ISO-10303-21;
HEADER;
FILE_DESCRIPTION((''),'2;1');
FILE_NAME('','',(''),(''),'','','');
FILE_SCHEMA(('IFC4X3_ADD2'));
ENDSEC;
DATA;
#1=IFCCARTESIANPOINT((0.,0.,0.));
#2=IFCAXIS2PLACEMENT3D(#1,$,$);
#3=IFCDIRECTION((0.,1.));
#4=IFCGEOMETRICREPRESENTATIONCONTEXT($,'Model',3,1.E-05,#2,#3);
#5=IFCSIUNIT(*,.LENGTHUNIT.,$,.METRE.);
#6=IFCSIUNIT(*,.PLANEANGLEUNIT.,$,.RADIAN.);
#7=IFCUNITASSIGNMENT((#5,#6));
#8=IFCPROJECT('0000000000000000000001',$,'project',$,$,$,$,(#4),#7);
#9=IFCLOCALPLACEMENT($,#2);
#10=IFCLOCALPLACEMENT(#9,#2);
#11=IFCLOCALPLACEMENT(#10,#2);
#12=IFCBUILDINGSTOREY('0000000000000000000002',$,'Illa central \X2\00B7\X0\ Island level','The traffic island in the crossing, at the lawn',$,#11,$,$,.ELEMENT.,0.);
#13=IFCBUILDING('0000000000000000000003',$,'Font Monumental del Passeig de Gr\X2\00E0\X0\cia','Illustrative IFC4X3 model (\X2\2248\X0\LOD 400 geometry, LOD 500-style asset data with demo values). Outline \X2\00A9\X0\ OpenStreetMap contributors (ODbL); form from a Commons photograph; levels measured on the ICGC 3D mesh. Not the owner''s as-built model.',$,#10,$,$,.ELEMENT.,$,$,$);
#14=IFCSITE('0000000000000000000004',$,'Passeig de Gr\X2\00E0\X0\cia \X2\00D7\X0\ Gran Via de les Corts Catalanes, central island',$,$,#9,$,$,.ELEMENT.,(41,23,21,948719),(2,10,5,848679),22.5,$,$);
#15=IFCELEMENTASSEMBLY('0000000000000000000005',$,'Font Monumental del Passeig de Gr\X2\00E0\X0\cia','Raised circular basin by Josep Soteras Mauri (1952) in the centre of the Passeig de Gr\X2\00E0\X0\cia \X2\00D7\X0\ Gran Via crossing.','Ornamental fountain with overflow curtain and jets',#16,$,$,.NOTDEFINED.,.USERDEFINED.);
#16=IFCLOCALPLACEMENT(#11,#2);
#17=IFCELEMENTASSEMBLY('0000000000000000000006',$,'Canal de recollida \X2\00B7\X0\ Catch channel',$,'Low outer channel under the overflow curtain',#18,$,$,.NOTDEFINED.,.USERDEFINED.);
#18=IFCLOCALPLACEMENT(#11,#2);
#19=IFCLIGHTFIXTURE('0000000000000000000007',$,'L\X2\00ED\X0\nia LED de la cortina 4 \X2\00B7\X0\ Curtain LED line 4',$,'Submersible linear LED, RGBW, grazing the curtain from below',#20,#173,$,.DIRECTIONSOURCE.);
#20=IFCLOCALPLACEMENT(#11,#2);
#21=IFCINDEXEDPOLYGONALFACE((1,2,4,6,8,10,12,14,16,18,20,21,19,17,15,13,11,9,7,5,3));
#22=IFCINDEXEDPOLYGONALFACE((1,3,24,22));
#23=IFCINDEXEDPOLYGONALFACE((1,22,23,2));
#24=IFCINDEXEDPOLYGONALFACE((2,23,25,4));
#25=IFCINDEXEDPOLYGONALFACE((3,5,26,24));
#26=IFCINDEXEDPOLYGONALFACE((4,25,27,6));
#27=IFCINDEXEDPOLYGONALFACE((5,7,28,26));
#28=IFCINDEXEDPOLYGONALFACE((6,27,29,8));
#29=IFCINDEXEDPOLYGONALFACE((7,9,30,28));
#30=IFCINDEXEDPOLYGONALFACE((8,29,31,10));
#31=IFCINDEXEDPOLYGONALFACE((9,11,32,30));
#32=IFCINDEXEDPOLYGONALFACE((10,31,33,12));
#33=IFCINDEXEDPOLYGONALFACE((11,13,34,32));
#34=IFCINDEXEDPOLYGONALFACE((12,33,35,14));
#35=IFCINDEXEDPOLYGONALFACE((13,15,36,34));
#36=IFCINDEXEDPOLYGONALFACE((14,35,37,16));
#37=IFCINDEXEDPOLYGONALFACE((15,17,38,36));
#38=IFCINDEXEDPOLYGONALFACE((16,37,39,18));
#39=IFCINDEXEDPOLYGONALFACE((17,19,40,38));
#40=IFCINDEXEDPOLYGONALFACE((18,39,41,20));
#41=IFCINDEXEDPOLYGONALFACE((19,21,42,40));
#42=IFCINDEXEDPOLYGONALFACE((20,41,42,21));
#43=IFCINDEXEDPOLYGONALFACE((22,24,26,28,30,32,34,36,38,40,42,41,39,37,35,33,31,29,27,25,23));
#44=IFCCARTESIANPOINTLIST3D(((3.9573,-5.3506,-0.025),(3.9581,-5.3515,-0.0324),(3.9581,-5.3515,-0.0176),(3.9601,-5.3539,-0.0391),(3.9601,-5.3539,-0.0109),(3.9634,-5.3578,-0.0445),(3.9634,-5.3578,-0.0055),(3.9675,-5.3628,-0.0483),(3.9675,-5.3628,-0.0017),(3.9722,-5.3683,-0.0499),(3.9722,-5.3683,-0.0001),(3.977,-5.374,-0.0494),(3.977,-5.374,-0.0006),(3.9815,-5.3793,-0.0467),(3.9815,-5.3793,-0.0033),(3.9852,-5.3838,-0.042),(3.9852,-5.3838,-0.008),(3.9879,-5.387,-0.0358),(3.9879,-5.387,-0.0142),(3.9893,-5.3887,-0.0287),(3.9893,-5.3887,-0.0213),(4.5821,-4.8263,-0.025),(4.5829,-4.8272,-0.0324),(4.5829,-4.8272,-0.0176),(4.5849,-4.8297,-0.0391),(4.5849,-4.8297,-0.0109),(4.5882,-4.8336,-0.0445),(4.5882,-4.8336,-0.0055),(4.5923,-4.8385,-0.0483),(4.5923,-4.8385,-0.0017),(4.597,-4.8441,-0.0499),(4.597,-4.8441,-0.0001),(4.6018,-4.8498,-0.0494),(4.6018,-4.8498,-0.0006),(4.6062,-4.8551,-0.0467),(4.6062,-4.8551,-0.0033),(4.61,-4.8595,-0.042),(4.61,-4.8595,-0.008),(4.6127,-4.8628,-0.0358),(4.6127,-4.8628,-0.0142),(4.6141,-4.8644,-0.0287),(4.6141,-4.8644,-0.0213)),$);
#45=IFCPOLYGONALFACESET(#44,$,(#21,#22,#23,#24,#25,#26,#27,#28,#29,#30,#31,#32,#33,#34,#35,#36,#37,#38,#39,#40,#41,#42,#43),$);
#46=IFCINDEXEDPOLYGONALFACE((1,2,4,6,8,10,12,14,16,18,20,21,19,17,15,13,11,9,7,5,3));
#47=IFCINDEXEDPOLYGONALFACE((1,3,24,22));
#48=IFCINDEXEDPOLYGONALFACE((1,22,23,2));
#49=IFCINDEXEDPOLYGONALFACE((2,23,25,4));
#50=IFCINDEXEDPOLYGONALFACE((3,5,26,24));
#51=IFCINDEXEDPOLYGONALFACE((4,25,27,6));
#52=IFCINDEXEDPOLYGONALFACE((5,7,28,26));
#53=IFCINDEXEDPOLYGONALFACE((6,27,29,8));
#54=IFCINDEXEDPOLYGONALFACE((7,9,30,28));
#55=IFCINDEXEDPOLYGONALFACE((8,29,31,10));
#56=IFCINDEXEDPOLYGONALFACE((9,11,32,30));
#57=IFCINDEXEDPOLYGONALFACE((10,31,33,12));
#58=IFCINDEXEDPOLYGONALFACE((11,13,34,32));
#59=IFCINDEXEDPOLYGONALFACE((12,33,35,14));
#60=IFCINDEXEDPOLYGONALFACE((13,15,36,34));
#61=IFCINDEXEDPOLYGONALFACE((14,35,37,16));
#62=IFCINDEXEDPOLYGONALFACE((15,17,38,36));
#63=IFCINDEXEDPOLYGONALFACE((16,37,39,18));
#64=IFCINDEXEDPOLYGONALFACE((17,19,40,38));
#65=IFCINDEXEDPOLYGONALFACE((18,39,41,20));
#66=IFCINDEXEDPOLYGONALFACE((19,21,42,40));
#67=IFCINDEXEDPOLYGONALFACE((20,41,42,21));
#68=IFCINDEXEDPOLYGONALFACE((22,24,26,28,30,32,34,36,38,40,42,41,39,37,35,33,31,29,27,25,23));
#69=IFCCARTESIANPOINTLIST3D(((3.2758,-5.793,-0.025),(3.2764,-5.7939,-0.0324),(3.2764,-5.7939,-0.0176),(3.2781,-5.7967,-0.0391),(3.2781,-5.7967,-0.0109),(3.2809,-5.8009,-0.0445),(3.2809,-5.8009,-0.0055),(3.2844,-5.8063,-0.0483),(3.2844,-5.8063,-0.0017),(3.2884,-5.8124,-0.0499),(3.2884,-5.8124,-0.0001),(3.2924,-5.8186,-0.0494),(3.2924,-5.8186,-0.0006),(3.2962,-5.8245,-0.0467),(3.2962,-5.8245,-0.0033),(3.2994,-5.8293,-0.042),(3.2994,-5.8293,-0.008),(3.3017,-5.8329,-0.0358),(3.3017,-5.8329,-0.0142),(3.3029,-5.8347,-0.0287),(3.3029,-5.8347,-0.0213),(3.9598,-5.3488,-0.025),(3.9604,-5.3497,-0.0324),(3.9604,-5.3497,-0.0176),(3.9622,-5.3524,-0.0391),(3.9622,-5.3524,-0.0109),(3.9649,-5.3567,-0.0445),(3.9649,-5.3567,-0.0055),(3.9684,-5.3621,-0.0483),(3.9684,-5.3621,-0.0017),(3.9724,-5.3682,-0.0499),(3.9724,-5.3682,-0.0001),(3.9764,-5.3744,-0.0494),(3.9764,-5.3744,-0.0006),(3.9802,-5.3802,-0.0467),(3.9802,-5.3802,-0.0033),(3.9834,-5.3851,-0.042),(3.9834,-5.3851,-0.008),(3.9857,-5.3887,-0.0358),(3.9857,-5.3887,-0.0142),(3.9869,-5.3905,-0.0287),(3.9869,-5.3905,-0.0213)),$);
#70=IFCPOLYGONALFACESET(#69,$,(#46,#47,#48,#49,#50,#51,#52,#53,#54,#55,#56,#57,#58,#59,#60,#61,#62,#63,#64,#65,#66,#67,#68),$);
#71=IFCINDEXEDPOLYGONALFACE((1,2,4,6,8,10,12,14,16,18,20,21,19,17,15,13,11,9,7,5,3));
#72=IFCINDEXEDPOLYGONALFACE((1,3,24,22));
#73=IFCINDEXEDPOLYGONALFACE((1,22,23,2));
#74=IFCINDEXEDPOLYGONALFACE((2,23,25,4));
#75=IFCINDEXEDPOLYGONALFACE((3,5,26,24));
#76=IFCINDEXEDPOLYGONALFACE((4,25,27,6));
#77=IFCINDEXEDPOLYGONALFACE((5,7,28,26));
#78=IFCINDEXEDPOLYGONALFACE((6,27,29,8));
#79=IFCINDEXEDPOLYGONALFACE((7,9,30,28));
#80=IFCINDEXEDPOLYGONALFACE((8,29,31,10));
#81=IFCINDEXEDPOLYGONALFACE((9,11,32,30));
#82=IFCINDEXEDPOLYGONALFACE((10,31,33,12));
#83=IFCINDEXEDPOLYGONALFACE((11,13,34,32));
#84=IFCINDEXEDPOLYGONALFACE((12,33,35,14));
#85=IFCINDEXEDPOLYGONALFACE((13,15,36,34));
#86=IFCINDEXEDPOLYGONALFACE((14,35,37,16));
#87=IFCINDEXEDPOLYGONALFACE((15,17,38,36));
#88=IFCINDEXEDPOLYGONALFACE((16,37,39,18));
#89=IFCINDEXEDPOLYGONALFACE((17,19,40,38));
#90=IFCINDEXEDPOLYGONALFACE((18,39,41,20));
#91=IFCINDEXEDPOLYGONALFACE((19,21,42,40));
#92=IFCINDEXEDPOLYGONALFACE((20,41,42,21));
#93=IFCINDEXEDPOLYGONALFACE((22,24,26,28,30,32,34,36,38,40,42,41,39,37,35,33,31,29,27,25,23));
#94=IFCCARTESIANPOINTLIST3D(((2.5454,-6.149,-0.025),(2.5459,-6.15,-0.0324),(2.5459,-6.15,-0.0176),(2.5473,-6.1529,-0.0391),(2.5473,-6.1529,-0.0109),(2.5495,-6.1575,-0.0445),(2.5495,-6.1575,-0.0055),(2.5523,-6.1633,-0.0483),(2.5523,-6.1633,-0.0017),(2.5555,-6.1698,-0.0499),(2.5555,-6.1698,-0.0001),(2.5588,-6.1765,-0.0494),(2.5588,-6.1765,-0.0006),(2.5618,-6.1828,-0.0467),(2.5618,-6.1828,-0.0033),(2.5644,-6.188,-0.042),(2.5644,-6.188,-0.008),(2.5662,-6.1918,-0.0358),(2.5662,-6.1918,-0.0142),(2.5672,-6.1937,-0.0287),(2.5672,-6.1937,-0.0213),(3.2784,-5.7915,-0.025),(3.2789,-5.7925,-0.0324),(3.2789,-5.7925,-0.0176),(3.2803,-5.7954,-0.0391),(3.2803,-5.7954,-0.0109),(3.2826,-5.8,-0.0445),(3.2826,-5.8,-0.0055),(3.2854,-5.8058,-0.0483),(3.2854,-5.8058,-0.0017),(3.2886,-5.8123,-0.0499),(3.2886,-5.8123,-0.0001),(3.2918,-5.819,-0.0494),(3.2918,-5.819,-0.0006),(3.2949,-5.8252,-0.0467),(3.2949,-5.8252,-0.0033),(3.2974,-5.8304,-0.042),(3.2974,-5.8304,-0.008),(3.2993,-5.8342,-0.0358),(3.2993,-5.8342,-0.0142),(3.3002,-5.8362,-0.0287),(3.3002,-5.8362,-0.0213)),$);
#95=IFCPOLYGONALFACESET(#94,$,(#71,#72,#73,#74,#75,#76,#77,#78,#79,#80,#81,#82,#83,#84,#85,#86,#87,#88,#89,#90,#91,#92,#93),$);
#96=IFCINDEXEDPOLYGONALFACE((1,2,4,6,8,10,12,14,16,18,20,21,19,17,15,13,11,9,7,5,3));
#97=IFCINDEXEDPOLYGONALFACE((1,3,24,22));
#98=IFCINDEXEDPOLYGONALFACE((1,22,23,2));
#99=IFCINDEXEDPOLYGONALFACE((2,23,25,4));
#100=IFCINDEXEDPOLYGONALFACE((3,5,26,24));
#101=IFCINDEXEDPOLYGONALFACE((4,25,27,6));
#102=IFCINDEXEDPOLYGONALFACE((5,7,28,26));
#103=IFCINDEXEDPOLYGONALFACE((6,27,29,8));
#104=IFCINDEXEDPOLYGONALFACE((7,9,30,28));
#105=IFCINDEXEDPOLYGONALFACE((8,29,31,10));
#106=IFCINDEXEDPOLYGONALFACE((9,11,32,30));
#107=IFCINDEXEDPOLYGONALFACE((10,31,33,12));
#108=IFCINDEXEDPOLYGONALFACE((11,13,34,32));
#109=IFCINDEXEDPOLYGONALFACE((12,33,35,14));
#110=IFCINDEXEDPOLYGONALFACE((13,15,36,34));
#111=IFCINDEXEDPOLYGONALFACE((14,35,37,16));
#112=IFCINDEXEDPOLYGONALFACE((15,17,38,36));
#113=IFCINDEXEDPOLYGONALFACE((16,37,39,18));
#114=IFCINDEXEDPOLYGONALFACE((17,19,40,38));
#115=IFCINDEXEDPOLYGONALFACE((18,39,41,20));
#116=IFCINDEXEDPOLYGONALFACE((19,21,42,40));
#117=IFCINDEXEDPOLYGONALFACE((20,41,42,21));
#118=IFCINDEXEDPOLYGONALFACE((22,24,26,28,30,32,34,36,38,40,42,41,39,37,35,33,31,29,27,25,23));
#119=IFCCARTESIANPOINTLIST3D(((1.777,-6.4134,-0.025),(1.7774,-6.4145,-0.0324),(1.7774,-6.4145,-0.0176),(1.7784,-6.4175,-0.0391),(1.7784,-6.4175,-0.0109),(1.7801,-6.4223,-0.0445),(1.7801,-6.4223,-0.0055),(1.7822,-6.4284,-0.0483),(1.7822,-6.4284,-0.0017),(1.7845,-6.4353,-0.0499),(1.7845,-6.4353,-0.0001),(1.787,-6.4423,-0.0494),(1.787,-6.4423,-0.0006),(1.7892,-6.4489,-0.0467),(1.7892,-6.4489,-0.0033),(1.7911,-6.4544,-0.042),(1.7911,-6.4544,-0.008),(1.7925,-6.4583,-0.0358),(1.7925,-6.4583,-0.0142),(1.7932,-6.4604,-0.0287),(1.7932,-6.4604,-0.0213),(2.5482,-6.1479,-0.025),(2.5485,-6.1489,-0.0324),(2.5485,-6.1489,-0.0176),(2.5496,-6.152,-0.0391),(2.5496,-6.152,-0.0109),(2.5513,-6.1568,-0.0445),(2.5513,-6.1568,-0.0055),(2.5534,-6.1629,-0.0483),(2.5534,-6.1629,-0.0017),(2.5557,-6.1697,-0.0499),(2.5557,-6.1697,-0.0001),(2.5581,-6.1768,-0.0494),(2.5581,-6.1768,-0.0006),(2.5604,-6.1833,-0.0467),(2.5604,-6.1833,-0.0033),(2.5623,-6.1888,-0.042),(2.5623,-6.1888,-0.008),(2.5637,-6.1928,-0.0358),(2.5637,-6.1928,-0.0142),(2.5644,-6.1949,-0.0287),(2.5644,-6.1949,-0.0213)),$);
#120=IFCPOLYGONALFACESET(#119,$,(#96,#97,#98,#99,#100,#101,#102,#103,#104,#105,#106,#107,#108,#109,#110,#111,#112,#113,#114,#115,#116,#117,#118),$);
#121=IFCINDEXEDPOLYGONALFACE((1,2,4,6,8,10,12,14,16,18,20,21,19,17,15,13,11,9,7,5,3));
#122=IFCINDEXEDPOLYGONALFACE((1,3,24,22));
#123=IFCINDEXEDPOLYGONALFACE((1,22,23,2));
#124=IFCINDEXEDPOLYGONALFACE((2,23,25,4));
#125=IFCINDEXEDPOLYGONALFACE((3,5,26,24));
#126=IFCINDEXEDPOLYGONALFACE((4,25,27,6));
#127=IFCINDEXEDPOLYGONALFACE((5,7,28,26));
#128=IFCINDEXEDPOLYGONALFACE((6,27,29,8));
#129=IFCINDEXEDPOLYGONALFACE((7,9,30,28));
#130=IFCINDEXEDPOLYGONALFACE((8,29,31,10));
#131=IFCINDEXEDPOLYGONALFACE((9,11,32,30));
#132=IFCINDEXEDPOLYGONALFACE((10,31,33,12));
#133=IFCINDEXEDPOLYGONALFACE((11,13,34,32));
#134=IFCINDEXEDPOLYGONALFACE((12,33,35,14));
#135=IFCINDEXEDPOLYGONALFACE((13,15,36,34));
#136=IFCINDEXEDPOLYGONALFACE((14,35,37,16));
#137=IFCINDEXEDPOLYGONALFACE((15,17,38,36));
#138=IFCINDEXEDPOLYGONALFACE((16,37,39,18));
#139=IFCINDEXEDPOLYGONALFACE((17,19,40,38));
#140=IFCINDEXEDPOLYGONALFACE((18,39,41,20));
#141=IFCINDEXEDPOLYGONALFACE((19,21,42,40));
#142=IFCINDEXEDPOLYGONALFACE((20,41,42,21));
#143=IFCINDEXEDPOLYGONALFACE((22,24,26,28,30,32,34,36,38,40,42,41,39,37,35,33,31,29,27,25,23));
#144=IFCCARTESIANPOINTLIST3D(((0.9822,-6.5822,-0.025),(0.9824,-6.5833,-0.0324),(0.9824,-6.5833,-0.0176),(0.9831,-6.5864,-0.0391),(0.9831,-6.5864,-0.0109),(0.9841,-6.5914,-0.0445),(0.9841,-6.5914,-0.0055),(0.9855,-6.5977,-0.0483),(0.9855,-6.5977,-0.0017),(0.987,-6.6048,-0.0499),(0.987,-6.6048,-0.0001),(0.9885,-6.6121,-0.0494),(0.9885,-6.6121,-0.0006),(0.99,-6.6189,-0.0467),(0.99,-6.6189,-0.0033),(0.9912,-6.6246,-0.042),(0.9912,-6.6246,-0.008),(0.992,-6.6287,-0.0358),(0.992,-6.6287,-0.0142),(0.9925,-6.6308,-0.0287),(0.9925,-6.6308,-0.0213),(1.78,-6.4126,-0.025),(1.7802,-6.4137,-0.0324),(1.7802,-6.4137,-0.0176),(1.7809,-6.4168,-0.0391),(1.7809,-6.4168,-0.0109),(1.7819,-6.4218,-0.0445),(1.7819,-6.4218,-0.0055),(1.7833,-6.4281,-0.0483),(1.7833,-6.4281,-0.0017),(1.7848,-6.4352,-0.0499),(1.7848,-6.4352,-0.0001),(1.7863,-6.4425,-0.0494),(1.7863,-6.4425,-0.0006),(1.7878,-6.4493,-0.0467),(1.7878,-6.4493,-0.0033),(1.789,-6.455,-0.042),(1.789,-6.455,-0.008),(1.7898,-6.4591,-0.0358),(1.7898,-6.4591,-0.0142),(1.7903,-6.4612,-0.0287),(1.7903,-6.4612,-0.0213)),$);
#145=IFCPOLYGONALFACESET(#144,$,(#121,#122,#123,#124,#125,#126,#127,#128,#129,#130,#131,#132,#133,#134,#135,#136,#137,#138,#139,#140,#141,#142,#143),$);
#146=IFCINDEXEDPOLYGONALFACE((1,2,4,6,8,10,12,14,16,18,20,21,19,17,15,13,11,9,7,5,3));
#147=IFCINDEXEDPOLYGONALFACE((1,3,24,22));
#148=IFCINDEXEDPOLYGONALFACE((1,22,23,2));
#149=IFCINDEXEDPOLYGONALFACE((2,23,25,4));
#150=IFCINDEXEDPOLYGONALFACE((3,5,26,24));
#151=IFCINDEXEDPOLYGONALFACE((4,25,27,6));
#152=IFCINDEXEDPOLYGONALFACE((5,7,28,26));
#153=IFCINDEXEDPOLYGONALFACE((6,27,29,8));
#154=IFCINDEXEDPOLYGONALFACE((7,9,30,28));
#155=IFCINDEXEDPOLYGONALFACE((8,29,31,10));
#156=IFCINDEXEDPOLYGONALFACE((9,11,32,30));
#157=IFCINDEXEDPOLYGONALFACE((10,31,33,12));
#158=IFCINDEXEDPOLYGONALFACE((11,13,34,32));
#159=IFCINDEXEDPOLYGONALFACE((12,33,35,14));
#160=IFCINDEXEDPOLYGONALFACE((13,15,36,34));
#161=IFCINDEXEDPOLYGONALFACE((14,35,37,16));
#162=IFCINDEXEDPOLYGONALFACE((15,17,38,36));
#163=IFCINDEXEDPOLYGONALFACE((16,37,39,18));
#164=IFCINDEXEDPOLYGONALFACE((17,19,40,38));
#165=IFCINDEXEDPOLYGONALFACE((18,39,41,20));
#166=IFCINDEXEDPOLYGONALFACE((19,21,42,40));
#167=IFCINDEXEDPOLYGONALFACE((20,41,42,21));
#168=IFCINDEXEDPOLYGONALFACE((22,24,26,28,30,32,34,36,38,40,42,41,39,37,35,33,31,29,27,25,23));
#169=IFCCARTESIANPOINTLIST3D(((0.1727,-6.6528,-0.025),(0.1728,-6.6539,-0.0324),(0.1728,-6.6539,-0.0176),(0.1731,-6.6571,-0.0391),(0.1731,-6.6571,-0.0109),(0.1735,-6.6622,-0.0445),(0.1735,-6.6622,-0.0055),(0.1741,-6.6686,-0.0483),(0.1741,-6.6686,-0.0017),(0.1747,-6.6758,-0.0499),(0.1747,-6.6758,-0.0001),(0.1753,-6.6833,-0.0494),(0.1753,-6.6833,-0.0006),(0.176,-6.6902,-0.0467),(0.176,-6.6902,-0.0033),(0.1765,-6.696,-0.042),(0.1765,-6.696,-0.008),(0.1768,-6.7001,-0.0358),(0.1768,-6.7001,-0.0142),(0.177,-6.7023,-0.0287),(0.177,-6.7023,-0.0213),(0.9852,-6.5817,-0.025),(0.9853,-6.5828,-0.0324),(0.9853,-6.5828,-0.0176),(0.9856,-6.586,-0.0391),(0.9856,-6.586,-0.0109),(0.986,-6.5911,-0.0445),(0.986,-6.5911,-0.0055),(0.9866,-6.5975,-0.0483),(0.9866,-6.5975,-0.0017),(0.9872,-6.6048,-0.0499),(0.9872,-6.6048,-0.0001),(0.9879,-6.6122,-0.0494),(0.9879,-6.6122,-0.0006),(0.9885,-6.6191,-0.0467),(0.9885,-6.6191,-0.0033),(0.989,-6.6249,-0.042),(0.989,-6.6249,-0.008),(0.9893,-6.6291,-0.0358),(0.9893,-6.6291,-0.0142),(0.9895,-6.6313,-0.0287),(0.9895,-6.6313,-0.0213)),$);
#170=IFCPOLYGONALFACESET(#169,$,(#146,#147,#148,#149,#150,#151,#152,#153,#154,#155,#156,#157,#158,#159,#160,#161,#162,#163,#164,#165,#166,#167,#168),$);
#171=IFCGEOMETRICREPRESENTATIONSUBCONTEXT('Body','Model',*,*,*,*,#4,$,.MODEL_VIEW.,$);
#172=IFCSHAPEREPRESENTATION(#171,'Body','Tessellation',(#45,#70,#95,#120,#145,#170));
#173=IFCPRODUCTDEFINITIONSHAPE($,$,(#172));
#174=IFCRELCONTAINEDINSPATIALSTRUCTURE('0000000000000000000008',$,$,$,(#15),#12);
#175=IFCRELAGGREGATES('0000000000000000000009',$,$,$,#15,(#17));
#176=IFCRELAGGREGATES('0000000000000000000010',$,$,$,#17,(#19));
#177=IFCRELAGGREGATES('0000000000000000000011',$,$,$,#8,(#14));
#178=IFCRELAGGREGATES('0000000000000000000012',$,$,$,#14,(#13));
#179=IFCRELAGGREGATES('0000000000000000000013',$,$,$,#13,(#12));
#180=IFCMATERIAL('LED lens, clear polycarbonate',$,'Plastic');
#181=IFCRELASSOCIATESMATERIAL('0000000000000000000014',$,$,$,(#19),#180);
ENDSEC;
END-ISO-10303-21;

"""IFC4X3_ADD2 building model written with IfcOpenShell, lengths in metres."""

from ifc_helpers import new_model, si_unit, direction, frame, origin, origin_2d_with_axis, place, context, subcontext, project, spatial, circle, extrude, material, element, aggregate, save


model = new_model("IFC4X3_ADD2")

# Units and contexts
model_context = context("Model", 3, precision=1e-05, world=origin(), true_north=direction((0.0, 1.0)))
body_context = subcontext(model_context, "Body", "Model", "MODEL_VIEW")
ifc_project = project(units=[si_unit("LENGTHUNIT", "METRE"), si_unit("PLANEANGLEUNIT", "RADIAN")], contexts=[model_context])

# Site, building, storey
site_placement = place(None, origin())
site = spatial("IfcSite", under=ifc_project, at=site_placement, Name="Passeig de Gràcia × Gran Via de les Corts Catalanes, central island", CompositionType="ELEMENT", RefLatitude=(41, 23, 21, 948719), RefLongitude=(2, 10, 5, 848679), RefElevation=22.5)
building_placement = place(site_placement, origin())
building = spatial("IfcBuilding", under=site, at=building_placement, Name="Font Monumental del Passeig de Gràcia", Description="Illustrative IFC4X3 model (≈LOD 400 geometry, LOD 500-style asset data with demo values). Outline © OpenStreetMap contributors (ODbL); form from a Commons photograph; levels measured on the ICGC 3D mesh. Not the owner's as-built model.", CompositionType="ELEMENT")
storey_placement = place(building_placement, origin())
storey = spatial("IfcBuildingStorey", under=building, at=storey_placement, Name="Illa central · Island level", Description="The traffic island in the crossing, at the lawn", CompositionType="ELEMENT", Elevation=0.0)

# Element assemblies, light fixture
assembly_1_placement = place(building_placement, origin())
assembly_1 = element("IfcElementAssembly", 1, at=assembly_1_placement, inside=storey, Name="Font Monumental del Passeig de Gràcia", Description="Raised circular basin by Josep Soteras Mauri (1952) in the centre of the Passeig de Gràcia × Gran Via crossing.", ObjectType="Ornamental fountain with overflow curtain and jets", AssemblyPlace="NOTDEFINED", PredefinedType="USERDEFINED")
assembly_2_placement = place(building_placement, origin())
assembly_2 = element("IfcElementAssembly", 2, at=assembly_2_placement, Name="Canal de recollida · Catch channel", ObjectType="Low outer channel under the overflow curtain", AssemblyPlace="NOTDEFINED", PredefinedType="USERDEFINED")
ifc_material_1 = material(Name="LED lens, clear polycarbonate", Category="Plastic")
light_fixture_1_placement = place(building_placement, origin())
light_fixture_1 = element("IfcLightFixture", 3, at=light_fixture_1_placement, material=ifc_material_1, Name="Línia LED de la cortina 4 · Curtain LED line 4", ObjectType="Submersible linear LED, RGBW, grazing the curtain from below", PredefinedType="DIRECTIONSOURCE", context=body_context, shape_type="SweptSolid", body=[
    extrude(circle(Radius=0.025, at=origin_2d_with_axis()), frame((4.5982, -4.8455, -0.025), z_axis=(-0.766044, -0.642788, 0.0), x_axis=(-0.642788, 0.766044, 0.0)), (0.0, 0.0, 1.0), 0.8156),
    extrude(circle(Radius=0.025, at=origin_2d_with_axis()), frame((3.9734, -5.3698, -0.025), z_axis=(-0.838671, -0.544639, 0.0), x_axis=(-0.544639, 0.838671, 0.0)), (0.0, 0.0, 1.0), 0.8156),
    extrude(circle(Radius=0.025, at=origin_2d_with_axis()), frame((3.2894, -5.814, -0.025), z_axis=(-0.898794, -0.438371, 0.0), x_axis=(-0.438371, 0.898794, 0.0)), (0.0, 0.0, 1.0), 0.8156),
    extrude(circle(Radius=0.025, at=origin_2d_with_axis()), frame((2.5563, -6.1715, -0.025), z_axis=(-0.945519, -0.325568, 0.0), x_axis=(-0.325568, 0.945519, 0.0)), (0.0, 0.0, 1.0), 0.8156),
    extrude(circle(Radius=0.025, at=origin_2d_with_axis()), frame((1.7852, -6.4371, -0.025), z_axis=(-0.978148, -0.207912, 0.0), x_axis=(-0.207912, 0.978148, 0.0)), (0.0, 0.0, 1.0), 0.8156),
    extrude(circle(Radius=0.025, at=origin_2d_with_axis()), frame((0.9874, -6.6066, -0.025), z_axis=(-0.996195, -0.087156, 0.0), x_axis=(-0.087156, 0.996195, 0.0)), (0.0, 0.0, 1.0), 0.8156),
])
aggregate(assembly_1, [assembly_2])
aggregate(assembly_2, [light_fixture_1])

save(model, "model.ifc")
